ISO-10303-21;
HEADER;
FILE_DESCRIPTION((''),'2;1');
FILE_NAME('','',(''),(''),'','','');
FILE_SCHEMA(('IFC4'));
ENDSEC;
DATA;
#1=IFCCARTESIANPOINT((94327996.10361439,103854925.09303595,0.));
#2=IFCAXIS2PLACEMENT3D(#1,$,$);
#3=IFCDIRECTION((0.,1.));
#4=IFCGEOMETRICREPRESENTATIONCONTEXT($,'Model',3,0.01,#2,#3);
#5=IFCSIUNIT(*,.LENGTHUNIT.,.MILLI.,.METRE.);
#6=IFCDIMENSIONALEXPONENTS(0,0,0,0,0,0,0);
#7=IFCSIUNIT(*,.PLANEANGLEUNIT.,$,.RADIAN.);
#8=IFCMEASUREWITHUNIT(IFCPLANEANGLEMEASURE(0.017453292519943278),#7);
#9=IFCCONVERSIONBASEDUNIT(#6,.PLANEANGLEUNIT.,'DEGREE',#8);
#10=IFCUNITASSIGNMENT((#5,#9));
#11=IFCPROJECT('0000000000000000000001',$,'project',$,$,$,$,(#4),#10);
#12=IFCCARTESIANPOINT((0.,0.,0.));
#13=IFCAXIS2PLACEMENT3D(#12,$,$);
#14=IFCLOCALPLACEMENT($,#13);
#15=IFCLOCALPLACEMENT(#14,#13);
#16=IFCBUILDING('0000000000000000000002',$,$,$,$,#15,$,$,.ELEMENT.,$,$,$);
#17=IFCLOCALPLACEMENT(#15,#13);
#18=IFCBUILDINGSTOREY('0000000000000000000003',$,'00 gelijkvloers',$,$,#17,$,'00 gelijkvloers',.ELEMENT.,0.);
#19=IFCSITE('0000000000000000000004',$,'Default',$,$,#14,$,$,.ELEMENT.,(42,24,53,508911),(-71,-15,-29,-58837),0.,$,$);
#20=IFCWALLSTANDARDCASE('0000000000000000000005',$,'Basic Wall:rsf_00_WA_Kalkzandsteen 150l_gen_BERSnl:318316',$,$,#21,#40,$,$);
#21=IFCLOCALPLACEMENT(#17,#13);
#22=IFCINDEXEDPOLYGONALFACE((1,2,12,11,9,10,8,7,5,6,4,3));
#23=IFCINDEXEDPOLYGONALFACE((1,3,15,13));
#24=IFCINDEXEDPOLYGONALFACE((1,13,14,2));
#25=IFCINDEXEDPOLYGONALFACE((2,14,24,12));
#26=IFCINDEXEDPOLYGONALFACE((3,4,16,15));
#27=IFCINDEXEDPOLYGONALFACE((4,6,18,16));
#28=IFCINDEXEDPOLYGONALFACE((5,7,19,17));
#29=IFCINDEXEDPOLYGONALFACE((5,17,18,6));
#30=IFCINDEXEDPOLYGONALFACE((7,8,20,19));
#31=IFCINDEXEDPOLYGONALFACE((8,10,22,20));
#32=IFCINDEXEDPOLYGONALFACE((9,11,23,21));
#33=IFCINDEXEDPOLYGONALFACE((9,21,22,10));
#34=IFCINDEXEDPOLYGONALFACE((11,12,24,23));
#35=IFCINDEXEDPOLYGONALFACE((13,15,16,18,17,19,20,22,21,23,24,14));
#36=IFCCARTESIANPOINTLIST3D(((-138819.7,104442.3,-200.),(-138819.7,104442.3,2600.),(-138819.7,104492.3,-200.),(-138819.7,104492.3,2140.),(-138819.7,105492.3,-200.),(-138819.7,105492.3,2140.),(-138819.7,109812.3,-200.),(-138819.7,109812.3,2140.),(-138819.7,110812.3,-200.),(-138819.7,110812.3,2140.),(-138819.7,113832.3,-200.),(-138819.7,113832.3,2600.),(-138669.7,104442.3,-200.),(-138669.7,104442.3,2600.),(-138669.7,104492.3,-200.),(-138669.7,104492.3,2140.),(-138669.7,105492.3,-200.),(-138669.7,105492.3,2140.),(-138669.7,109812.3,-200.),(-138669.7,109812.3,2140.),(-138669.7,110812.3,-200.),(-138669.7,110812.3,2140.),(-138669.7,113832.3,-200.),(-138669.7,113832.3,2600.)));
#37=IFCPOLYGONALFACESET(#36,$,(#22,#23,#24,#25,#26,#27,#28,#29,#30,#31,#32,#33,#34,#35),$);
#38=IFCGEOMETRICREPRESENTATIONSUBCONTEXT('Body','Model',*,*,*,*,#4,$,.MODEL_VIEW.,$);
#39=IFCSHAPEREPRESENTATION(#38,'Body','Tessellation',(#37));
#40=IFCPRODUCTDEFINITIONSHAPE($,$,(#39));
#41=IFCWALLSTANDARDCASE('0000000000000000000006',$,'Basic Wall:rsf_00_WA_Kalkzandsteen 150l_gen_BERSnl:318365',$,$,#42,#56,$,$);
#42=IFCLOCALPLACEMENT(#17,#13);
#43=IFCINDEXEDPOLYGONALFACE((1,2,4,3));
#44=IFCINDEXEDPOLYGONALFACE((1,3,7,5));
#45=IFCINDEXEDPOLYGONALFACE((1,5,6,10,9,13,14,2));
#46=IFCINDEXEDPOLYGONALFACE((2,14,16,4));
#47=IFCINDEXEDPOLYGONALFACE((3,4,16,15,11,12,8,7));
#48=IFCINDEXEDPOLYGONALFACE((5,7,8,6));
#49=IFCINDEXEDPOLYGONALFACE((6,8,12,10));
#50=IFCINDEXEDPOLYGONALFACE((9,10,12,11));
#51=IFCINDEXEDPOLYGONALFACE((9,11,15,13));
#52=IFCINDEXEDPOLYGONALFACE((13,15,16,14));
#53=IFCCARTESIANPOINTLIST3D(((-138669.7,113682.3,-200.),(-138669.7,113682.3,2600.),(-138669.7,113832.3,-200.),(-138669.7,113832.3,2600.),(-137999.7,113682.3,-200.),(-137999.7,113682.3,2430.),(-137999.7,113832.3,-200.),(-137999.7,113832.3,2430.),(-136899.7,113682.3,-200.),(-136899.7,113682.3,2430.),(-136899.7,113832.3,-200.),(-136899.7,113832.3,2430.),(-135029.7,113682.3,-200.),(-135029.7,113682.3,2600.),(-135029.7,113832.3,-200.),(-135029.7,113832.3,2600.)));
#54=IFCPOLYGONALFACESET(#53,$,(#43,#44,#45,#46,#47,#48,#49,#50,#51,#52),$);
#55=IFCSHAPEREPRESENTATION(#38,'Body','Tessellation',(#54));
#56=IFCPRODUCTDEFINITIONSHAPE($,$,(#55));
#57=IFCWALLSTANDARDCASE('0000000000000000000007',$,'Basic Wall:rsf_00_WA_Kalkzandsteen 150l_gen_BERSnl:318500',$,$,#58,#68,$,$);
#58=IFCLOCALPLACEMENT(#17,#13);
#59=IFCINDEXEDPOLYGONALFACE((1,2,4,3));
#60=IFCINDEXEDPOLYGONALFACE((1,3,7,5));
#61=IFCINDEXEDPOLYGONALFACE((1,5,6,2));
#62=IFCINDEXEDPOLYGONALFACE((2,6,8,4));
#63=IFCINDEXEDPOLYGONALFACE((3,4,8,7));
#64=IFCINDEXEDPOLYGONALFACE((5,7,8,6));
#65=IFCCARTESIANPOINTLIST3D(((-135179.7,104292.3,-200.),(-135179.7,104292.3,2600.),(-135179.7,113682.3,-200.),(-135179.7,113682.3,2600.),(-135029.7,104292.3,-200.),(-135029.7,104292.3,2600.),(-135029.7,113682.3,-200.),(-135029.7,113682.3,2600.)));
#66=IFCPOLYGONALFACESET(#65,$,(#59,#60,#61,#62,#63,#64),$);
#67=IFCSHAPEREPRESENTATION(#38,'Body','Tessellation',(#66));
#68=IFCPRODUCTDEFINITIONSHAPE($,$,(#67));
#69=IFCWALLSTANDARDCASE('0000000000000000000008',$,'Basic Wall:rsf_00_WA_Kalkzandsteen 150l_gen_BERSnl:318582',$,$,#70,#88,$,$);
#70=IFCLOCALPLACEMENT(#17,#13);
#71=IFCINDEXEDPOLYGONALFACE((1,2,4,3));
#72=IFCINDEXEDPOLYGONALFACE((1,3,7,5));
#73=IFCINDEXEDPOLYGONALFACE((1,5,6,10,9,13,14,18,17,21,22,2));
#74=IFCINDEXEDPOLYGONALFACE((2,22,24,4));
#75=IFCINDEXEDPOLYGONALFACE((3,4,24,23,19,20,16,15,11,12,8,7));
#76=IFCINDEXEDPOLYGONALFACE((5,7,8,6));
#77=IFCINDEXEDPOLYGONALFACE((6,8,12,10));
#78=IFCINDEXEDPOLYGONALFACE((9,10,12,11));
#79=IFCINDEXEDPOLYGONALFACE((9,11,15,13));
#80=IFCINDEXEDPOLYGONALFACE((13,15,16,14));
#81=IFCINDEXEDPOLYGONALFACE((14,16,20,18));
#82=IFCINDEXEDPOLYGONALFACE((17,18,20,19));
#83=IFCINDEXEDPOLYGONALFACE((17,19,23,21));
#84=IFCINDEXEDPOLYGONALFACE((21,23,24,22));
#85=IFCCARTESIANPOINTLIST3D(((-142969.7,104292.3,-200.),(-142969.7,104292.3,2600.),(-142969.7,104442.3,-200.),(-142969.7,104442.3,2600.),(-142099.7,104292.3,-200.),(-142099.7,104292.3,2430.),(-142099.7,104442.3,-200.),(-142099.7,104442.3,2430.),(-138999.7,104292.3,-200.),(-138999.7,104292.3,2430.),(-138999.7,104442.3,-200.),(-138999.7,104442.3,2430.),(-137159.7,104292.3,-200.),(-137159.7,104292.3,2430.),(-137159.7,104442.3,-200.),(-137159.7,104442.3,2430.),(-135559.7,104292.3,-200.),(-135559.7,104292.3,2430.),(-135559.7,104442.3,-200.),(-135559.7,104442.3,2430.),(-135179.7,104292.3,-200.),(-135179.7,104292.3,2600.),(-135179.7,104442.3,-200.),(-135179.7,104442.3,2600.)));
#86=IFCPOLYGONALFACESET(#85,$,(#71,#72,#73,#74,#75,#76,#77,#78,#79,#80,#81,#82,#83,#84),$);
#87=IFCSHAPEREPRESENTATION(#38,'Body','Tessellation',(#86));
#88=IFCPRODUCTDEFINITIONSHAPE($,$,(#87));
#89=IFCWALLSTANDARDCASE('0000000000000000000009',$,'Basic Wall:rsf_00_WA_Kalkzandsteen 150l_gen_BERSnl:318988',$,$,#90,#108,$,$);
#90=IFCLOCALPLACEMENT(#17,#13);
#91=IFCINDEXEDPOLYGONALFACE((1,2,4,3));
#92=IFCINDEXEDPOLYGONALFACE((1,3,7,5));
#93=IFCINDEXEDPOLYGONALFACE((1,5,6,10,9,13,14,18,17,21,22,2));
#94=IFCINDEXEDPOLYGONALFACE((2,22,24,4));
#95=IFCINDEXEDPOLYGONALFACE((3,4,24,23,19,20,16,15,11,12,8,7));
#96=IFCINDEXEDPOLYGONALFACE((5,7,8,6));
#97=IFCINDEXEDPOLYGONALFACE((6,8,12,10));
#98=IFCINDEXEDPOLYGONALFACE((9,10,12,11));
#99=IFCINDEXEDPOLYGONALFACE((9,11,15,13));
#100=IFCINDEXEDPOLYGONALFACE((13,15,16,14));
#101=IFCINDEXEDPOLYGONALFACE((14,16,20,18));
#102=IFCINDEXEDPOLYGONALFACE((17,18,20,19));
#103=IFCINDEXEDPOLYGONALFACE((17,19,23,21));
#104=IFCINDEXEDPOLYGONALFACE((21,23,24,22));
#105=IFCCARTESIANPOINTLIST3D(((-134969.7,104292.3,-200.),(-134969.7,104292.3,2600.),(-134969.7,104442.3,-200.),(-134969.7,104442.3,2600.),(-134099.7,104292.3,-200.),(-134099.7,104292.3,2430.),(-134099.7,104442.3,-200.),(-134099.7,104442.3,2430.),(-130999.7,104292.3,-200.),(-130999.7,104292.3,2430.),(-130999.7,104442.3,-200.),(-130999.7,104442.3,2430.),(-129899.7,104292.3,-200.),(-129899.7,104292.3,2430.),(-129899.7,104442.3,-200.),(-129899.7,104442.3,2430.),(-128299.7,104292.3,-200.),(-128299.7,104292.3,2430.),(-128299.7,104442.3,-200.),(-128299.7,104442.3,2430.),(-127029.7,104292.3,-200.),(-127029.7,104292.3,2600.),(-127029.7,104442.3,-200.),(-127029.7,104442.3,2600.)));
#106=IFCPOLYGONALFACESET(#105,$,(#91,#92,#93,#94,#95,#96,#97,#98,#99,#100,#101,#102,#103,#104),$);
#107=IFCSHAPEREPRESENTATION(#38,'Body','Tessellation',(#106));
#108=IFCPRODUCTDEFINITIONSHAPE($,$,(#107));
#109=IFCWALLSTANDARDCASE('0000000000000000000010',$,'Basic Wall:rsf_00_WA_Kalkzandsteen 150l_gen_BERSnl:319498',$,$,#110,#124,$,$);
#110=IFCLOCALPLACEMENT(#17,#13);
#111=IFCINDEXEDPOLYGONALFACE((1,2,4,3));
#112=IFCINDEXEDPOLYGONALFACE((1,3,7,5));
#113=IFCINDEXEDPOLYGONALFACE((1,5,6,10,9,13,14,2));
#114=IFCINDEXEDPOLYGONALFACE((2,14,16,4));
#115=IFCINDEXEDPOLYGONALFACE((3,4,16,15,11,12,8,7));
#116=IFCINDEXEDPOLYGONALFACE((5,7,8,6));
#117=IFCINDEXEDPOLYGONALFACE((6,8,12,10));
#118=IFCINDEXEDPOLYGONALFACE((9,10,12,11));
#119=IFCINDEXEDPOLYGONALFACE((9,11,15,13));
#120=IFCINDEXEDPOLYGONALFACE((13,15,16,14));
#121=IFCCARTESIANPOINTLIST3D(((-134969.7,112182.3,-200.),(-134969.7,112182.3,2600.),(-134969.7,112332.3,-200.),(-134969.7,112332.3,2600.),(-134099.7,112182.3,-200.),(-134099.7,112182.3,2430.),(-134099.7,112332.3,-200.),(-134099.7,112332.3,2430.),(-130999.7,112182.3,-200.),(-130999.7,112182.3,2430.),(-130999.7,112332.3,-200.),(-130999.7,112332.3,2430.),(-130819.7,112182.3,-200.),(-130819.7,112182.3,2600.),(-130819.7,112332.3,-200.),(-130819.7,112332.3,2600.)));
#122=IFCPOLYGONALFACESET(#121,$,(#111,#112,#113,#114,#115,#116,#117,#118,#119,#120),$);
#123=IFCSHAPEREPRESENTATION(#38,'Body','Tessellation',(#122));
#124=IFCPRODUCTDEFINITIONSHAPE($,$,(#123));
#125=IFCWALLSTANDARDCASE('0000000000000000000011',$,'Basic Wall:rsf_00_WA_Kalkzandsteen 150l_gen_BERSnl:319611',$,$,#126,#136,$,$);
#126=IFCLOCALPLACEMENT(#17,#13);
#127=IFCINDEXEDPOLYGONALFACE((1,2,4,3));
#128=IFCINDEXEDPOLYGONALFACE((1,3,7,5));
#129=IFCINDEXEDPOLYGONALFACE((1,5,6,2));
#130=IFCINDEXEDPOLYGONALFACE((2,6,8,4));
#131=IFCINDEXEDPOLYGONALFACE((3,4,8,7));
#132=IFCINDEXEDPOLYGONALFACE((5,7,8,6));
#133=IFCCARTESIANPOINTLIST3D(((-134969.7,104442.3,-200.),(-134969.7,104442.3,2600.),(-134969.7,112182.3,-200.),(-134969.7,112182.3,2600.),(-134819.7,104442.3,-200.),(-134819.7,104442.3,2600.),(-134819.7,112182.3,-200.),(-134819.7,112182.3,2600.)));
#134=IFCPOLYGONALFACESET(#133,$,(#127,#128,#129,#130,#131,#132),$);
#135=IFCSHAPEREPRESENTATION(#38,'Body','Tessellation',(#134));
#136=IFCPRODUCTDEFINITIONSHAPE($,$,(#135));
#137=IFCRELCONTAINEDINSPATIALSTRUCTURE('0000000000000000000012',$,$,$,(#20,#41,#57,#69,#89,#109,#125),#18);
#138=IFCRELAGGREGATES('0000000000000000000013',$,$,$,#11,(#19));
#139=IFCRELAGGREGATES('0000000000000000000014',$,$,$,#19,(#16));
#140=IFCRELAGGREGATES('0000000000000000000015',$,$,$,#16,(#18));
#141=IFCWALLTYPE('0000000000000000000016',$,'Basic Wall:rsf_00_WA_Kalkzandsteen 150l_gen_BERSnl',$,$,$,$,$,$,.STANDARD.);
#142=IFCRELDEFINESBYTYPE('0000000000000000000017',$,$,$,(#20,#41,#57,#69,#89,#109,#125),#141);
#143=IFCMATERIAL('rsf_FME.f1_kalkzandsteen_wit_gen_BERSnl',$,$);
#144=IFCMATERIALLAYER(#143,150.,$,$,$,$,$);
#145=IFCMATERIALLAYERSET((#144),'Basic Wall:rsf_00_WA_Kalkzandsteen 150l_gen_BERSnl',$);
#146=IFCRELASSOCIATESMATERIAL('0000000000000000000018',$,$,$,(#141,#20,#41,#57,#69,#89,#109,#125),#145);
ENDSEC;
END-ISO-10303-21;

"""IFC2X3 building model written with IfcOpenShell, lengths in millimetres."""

from ifc_helpers import new_model, entity, si_unit, converted_unit, direction, frame, frame_2d, origin, origin_2d_with_axis, place, context, subcontext, project, spatial, polyline, rectangle, extrude, clip, bounded_halfspace, material, layer, layer_set, layer_usage, type_object, element, save


model = new_model("IFC2X3")

# Units and contexts
model_context = context("Model", 3, precision=0.01, world=frame((94327996.10361439, 103854925.09303595, 0.0)), true_north=direction((0.0, 1.0)))
body_context = subcontext(model_context, "Body", "Model", "MODEL_VIEW")
ifc_project = project(units=[si_unit("LENGTHUNIT", "METRE", prefix="MILLI"), converted_unit("PLANEANGLEUNIT", "DEGREE", entity("IfcPlaneAngleMeasure", 0.017453292519943278), si_unit("PLANEANGLEUNIT", "RADIAN"), dimensions=[0, 0, 0, 0, 0, 0, 0])], contexts=[model_context])

# Site, building, storey
site_placement = place(None, origin())
site = spatial("IfcSite", under=ifc_project, at=site_placement, Name="Default", CompositionType="ELEMENT", RefLatitude=(42, 24, 53, 508911), RefLongitude=(-71, -15, -29, -58837), RefElevation=0.0)
building_placement = place(site_placement, origin())
building = spatial("IfcBuilding", under=site, at=building_placement, CompositionType="ELEMENT")
storey_placement = place(building_placement, origin())
storey = spatial("IfcBuildingStorey", under=building, at=storey_placement, Name="00 gelijkvloers", LongName="00 gelijkvloers", CompositionType="ELEMENT", Elevation=0.0)

# Wall, openings
ifc_material_1 = material(Name="rsf_FME.f1_kalkzandsteen_wit_gen_BERSnl")
ifc_layer_1 = layer(ifc_material_1, 150.0)
ifc_layer_set_1 = layer_set([ifc_layer_1], Name="Basic Wall:rsf_00_WA_Kalkzandsteen 150l_gen_BERSnl")
ifc_layer_usage_1 = layer_usage(ifc_layer_set_1, "AXIS2", "NEGATIVE", 75.0)
wall_type_1 = type_object("IfcWallType", Name="Basic Wall:rsf_00_WA_Kalkzandsteen 150l_gen_BERSnl", PredefinedType="STANDARD", material=ifc_layer_set_1)
wall_1_placement = place(storey_placement, frame((-138744.7, 104442.3, -200.0), z_axis=(0.0, 0.0, 1.0), x_axis=(0.0, 1.0, 0.0)))
wall_1 = element("IfcWallStandardCase", 1, at=wall_1_placement, inside=storey, type_object=wall_type_1, material=ifc_layer_usage_1, Name="Basic Wall:rsf_00_WA_Kalkzandsteen 150l_gen_BERSnl:318316", context=body_context, shape_type="Clipping", body=[
    clip(extrude(rectangle(XDim=150.0, YDim=9390.0, at=frame_2d((4695.0, 0.0), x_axis=(0.0, -1.0))), origin(), (0.0, 0.0, 1.0), 2800.0), bounded_halfspace(frame((0.0, 75.0, 2800.0), z_axis=(0.0, 0.0, -1.0), x_axis=(1.0, 0.0, 0.0)), True, frame((0.0, 75.0, 2800.0)), polyline([(0.0, 0.0), (0.0, -150.0), (9240.0, -150.0), (9390.0, -150.0), (9390.0, 0.0), (7890.0, 0.0), (7740.0, 0.0), (0.0, 0.0)]))),
])
opening_1_placement = place(wall_1_placement, frame((-104442.3, -138744.7, 200.0), z_axis=(0.0, 0.0, 1.0), x_axis=(0.0, -1.0, 0.0)))
element("IfcOpeningElement", 2, at=opening_1_placement, cuts=wall_1, ObjectType="Opening", context=body_context, shape_type="SweptSolid", body=[
    extrude(rectangle(XDim=2340.0, YDim=1000.0, at=frame_2d((0.0, 0.0), x_axis=(1.0, 0.0))), frame((-137295.7, 104992.3, 970.0), z_axis=(-1.0, 0.0, 0.0), x_axis=(0.0, 0.0, 1.0)), (0.0, 0.0, 1.0), 3048.0),
])
opening_2_placement = place(wall_1_placement, frame((-104442.3, -138744.7, 200.0), z_axis=(0.0, 0.0, 1.0), x_axis=(0.0, -1.0, 0.0)))
element("IfcOpeningElement", 3, at=opening_2_placement, cuts=wall_1, ObjectType="Opening", context=body_context, shape_type="SweptSolid", body=[
    extrude(rectangle(XDim=2340.0, YDim=1000.0, at=frame_2d((0.0, 0.0), x_axis=(1.0, 0.0))), frame((-137295.7, 110312.3, 970.0), z_axis=(-1.0, 0.0, 0.0), x_axis=(0.0, 0.0, 1.0)), (0.0, 0.0, 1.0), 3048.0),
])

# Wall, opening
ifc_layer_usage_2 = layer_usage(ifc_layer_set_1, "AXIS2", "NEGATIVE", 75.0)
wall_2_placement = place(storey_placement, frame((-138669.7, 113757.3, -200.0)))
wall_2 = element("IfcWallStandardCase", 4, at=wall_2_placement, inside=storey, type_object=wall_type_1, material=ifc_layer_usage_2, Name="Basic Wall:rsf_00_WA_Kalkzandsteen 150l_gen_BERSnl:318365", context=body_context, shape_type="Clipping", body=[
    clip(extrude(rectangle(XDim=3640.0, YDim=150.0, at=frame_2d((1820.0, 0.0), x_axis=(1.0, 0.0))), origin(), (0.0, 0.0, 1.0), 2800.0), bounded_halfspace(frame((0.0, -75.0, 2800.0), z_axis=(0.0, 0.0, -1.0), x_axis=(0.0, 1.0, 0.0)), True, frame((0.0, -75.0, 2800.0)), polyline([(0.0, 0.0), (3490.0, 0.0), (3640.0, 0.0), (3640.0, 150.0), (0.0, 150.0), (0.0, 0.0)]))),
])
opening_3_placement = place(wall_2_placement, frame((138669.7, -113757.3, 200.0)))
element("IfcOpeningElement", 5, at=opening_3_placement, cuts=wall_2, ObjectType="Opening", context=body_context, shape_type="SweptSolid", body=[
    extrude(rectangle(XDim=2630.0, YDim=1100.0, at=origin_2d_with_axis()), frame((-137449.7, 112308.3, 1115.0), z_axis=(0.0, 1.0, 0.0), x_axis=(0.0, 0.0, 1.0)), (0.0, 0.0, 1.0), 3048.0),
])

# Wall
ifc_layer_usage_3 = layer_usage(ifc_layer_set_1, "AXIS2", "NEGATIVE", 75.0)
wall_3_placement = place(storey_placement, frame((-135104.7, 113682.3, -200.0), z_axis=(0.0, 0.0, 1.0), x_axis=(0.0, -1.0, 0.0)))
element("IfcWallStandardCase", 6, at=wall_3_placement, inside=storey, type_object=wall_type_1, material=ifc_layer_usage_3, Name="Basic Wall:rsf_00_WA_Kalkzandsteen 150l_gen_BERSnl:318500", context=body_context, shape_type="Clipping", body=[
    clip(extrude(rectangle(XDim=9390.0, YDim=150.0, at=frame_2d((4695.0, 0.0), x_axis=(-1.0, 0.0))), origin(), (0.0, 0.0, 1.0), 2800.0), bounded_halfspace(frame((0.0, -75.0, 2800.0), z_axis=(0.0, 0.0, -1.0), x_axis=(-1.0, 0.0, 0.0)), True, frame((0.0, -75.0, 2800.0)), polyline([(0.0, 0.0), (9240.0, 0.0), (9390.0, 0.0), (9390.0, 150.0), (1350.0, 150.0), (0.0, 150.0), (0.0, 0.0)]))),
])

# Walls, openings
ifc_layer_usage_4 = layer_usage(ifc_layer_set_1, "AXIS2", "NEGATIVE", 75.0)
wall_4_placement = place(storey_placement, frame((-135179.7, 104367.3, -200.0), z_axis=(0.0, 0.0, 1.0), x_axis=(-1.0, 0.0, 0.0)))
wall_4 = element("IfcWallStandardCase", 7, at=wall_4_placement, inside=storey, type_object=wall_type_1, material=ifc_layer_usage_4, Name="Basic Wall:rsf_00_WA_Kalkzandsteen 150l_gen_BERSnl:318582", context=body_context, shape_type="Clipping", body=[
    clip(extrude(rectangle(XDim=7790.0, YDim=150.0, at=frame_2d((3895.0, 0.0), x_axis=(-1.0, 0.0))), origin(), (0.0, 0.0, 1.0), 2800.0), bounded_halfspace(frame((0.0, -75.0, 2800.0), z_axis=(0.0, 0.0, -1.0), x_axis=(0.0, -1.0, 0.0)), True, frame((0.0, -75.0, 2800.0)), polyline([(0.0, 0.0), (3490.0, 0.0), (3640.0, 0.0), (7640.0, 0.0), (7790.0, 0.0), (7790.0, 150.0), (0.0, 150.0), (0.0, 0.0)]))),
])
opening_4_placement = place(wall_4_placement, frame((-135179.7, 104367.3, 200.0), z_axis=(0.0, 0.0, 1.0), x_axis=(-1.0, 0.0, 0.0)))
element("IfcOpeningElement", 8, at=opening_4_placement, cuts=wall_4, ObjectType="Opening", context=body_context, shape_type="SweptSolid", body=[
    extrude(rectangle(XDim=2630.0, YDim=3100.0, at=frame_2d((0.0, 0.0), x_axis=(0.0, 1.0))), frame((-140549.7, 105966.3, 1115.0), z_axis=(0.0, -1.0, 0.0), x_axis=(1.0, 0.0, 0.0)), (0.0, 0.0, 1.0), 3048.0),
])
opening_5_placement = place(wall_4_placement, frame((-135179.7, 104367.3, 200.0), z_axis=(0.0, 0.0, 1.0), x_axis=(-1.0, 0.0, 0.0)))
element("IfcOpeningElement", 9, at=opening_5_placement, cuts=wall_4, ObjectType="Opening", context=body_context, shape_type="SweptSolid", body=[
    extrude(rectangle(XDim=2630.0, YDim=1600.0, at=frame_2d((0.0, 0.0), x_axis=(1.0, 0.0))), frame((-136359.7, 105816.3, 1115.0), z_axis=(0.0, -1.0, 0.0), x_axis=(0.0, 0.0, 1.0)), (0.0, 0.0, 1.0), 3048.0),
])
ifc_layer_usage_5 = layer_usage(ifc_layer_set_1, "AXIS2", "POSITIVE", -75.0)
wall_5_placement = place(storey_placement, frame((-134969.7, 104367.3, -200.0)))
wall_5 = element("IfcWallStandardCase", 10, at=wall_5_placement, inside=storey, type_object=wall_type_1, material=ifc_layer_usage_5, Name="Basic Wall:rsf_00_WA_Kalkzandsteen 150l_gen_BERSnl:318988", context=body_context, shape_type="Clipping", body=[
    clip(extrude(rectangle(XDim=7940.0, YDim=150.0, at=frame_2d((3970.0, 0.0), x_axis=(1.0, 0.0))), origin(), (0.0, 0.0, 1.0), 2800.0), bounded_halfspace(frame((0.0, -75.0, 2800.0), z_axis=(0.0, 0.0, -1.0), x_axis=(0.0, 1.0, 0.0)), True, frame((0.0, -75.0, 2800.0)), polyline([(0.0, 0.0), (7940.0, 0.0), (7940.0, 150.0), (7790.0, 150.0), (4300.0, 150.0), (4150.0, 150.0), (150.0, 150.0), (0.0, 150.0), (0.0, 0.0)]))),
])
opening_6_placement = place(wall_5_placement, frame((134969.7, -104367.3, 200.0)))
element("IfcOpeningElement", 11, at=opening_6_placement, cuts=wall_5, ObjectType="Opening", context=body_context, shape_type="SweptSolid", body=[
    extrude(rectangle(XDim=2630.0, YDim=3100.0, at=frame_2d((0.0, 0.0), x_axis=(1.0, 0.0))), frame((-132549.7, 102918.3, 1115.0), z_axis=(0.0, 1.0, 0.0), x_axis=(0.0, 0.0, 1.0)), (0.0, 0.0, 1.0), 3048.0),
])
opening_7_placement = place(wall_5_placement, frame((134969.7, -104367.3, 200.0)))
element("IfcOpeningElement", 12, at=opening_7_placement, cuts=wall_5, ObjectType="Opening", context=body_context, shape_type="SweptSolid", body=[
    extrude(rectangle(XDim=2630.0, YDim=1600.0, at=frame_2d((0.0, 0.0), x_axis=(1.0, 0.0))), frame((-129099.7, 102918.3, 1115.0), z_axis=(0.0, 1.0, 0.0), x_axis=(0.0, 0.0, 1.0)), (0.0, 0.0, 1.0), 3048.0),
])

# Wall, opening
ifc_layer_usage_6 = layer_usage(ifc_layer_set_1, "AXIS2", "NEGATIVE", 75.0)
wall_6_placement = place(storey_placement, frame((-130819.7, 112257.3, -200.0), z_axis=(0.0, 0.0, 1.0), x_axis=(-1.0, 0.0, 0.0)))
wall_6 = element("IfcWallStandardCase", 13, at=wall_6_placement, inside=storey, type_object=wall_type_1, material=ifc_layer_usage_6, Name="Basic Wall:rsf_00_WA_Kalkzandsteen 150l_gen_BERSnl:319498", context=body_context, shape_type="Clipping", body=[
    clip(extrude(rectangle(XDim=4150.0, YDim=150.0, at=frame_2d((2075.0, 0.0), x_axis=(-1.0, 0.0))), origin(), (0.0, 0.0, 1.0), 2800.0), bounded_halfspace(frame((0.0, -75.0, 2800.0), z_axis=(0.0, 0.0, -1.0), x_axis=(0.0, -1.0, 0.0)), True, frame((0.0, -75.0, 2800.0)), polyline([(0.0, 0.0), (4150.0, 0.0), (4150.0, 150.0), (4000.0, 150.0), (0.0, 150.0), (0.0, 0.0)]))),
])
opening_8_placement = place(wall_6_placement, frame((-130819.7, 112257.3, 200.0), z_axis=(0.0, 0.0, 1.0), x_axis=(-1.0, 0.0, 0.0)))
element("IfcOpeningElement", 14, at=opening_8_placement, cuts=wall_6, ObjectType="Opening", context=body_context, shape_type="SweptSolid", body=[
    extrude(rectangle(XDim=2630.0, YDim=3100.0, at=frame_2d((0.0, 0.0), x_axis=(0.0, 1.0))), frame((-132549.7, 113856.3, 1115.0), z_axis=(0.0, -1.0, 0.0), x_axis=(1.0, 0.0, 0.0)), (0.0, 0.0, 1.0), 3048.0),
])

# Wall
ifc_layer_usage_7 = layer_usage(ifc_layer_set_1, "AXIS2", "NEGATIVE", 75.0)
wall_7_placement = place(storey_placement, frame((-134894.7, 112182.3, -200.0), z_axis=(0.0, 0.0, 1.0), x_axis=(0.0, -1.0, 0.0)))
element("IfcWallStandardCase", 15, at=wall_7_placement, inside=storey, type_object=wall_type_1, material=ifc_layer_usage_7, Name="Basic Wall:rsf_00_WA_Kalkzandsteen 150l_gen_BERSnl:319611", context=body_context, shape_type="Clipping", body=[
    clip(extrude(rectangle(XDim=7740.0, YDim=150.0, at=frame_2d((3870.0, 0.0), x_axis=(-1.0, 0.0))), origin(), (0.0, 0.0, 1.0), 2800.0), bounded_halfspace(frame((0.0, -75.0, 2800.0), z_axis=(0.0, 0.0, -1.0), x_axis=(-1.0, 0.0, 0.0)), True, frame((0.0, -75.0, 2800.0)), polyline([(0.0, 0.0), (7740.0, 0.0), (7740.0, 150.0), (0.0, 150.0), (0.0, 0.0)]))),
])

save(model, "model.ifc")
